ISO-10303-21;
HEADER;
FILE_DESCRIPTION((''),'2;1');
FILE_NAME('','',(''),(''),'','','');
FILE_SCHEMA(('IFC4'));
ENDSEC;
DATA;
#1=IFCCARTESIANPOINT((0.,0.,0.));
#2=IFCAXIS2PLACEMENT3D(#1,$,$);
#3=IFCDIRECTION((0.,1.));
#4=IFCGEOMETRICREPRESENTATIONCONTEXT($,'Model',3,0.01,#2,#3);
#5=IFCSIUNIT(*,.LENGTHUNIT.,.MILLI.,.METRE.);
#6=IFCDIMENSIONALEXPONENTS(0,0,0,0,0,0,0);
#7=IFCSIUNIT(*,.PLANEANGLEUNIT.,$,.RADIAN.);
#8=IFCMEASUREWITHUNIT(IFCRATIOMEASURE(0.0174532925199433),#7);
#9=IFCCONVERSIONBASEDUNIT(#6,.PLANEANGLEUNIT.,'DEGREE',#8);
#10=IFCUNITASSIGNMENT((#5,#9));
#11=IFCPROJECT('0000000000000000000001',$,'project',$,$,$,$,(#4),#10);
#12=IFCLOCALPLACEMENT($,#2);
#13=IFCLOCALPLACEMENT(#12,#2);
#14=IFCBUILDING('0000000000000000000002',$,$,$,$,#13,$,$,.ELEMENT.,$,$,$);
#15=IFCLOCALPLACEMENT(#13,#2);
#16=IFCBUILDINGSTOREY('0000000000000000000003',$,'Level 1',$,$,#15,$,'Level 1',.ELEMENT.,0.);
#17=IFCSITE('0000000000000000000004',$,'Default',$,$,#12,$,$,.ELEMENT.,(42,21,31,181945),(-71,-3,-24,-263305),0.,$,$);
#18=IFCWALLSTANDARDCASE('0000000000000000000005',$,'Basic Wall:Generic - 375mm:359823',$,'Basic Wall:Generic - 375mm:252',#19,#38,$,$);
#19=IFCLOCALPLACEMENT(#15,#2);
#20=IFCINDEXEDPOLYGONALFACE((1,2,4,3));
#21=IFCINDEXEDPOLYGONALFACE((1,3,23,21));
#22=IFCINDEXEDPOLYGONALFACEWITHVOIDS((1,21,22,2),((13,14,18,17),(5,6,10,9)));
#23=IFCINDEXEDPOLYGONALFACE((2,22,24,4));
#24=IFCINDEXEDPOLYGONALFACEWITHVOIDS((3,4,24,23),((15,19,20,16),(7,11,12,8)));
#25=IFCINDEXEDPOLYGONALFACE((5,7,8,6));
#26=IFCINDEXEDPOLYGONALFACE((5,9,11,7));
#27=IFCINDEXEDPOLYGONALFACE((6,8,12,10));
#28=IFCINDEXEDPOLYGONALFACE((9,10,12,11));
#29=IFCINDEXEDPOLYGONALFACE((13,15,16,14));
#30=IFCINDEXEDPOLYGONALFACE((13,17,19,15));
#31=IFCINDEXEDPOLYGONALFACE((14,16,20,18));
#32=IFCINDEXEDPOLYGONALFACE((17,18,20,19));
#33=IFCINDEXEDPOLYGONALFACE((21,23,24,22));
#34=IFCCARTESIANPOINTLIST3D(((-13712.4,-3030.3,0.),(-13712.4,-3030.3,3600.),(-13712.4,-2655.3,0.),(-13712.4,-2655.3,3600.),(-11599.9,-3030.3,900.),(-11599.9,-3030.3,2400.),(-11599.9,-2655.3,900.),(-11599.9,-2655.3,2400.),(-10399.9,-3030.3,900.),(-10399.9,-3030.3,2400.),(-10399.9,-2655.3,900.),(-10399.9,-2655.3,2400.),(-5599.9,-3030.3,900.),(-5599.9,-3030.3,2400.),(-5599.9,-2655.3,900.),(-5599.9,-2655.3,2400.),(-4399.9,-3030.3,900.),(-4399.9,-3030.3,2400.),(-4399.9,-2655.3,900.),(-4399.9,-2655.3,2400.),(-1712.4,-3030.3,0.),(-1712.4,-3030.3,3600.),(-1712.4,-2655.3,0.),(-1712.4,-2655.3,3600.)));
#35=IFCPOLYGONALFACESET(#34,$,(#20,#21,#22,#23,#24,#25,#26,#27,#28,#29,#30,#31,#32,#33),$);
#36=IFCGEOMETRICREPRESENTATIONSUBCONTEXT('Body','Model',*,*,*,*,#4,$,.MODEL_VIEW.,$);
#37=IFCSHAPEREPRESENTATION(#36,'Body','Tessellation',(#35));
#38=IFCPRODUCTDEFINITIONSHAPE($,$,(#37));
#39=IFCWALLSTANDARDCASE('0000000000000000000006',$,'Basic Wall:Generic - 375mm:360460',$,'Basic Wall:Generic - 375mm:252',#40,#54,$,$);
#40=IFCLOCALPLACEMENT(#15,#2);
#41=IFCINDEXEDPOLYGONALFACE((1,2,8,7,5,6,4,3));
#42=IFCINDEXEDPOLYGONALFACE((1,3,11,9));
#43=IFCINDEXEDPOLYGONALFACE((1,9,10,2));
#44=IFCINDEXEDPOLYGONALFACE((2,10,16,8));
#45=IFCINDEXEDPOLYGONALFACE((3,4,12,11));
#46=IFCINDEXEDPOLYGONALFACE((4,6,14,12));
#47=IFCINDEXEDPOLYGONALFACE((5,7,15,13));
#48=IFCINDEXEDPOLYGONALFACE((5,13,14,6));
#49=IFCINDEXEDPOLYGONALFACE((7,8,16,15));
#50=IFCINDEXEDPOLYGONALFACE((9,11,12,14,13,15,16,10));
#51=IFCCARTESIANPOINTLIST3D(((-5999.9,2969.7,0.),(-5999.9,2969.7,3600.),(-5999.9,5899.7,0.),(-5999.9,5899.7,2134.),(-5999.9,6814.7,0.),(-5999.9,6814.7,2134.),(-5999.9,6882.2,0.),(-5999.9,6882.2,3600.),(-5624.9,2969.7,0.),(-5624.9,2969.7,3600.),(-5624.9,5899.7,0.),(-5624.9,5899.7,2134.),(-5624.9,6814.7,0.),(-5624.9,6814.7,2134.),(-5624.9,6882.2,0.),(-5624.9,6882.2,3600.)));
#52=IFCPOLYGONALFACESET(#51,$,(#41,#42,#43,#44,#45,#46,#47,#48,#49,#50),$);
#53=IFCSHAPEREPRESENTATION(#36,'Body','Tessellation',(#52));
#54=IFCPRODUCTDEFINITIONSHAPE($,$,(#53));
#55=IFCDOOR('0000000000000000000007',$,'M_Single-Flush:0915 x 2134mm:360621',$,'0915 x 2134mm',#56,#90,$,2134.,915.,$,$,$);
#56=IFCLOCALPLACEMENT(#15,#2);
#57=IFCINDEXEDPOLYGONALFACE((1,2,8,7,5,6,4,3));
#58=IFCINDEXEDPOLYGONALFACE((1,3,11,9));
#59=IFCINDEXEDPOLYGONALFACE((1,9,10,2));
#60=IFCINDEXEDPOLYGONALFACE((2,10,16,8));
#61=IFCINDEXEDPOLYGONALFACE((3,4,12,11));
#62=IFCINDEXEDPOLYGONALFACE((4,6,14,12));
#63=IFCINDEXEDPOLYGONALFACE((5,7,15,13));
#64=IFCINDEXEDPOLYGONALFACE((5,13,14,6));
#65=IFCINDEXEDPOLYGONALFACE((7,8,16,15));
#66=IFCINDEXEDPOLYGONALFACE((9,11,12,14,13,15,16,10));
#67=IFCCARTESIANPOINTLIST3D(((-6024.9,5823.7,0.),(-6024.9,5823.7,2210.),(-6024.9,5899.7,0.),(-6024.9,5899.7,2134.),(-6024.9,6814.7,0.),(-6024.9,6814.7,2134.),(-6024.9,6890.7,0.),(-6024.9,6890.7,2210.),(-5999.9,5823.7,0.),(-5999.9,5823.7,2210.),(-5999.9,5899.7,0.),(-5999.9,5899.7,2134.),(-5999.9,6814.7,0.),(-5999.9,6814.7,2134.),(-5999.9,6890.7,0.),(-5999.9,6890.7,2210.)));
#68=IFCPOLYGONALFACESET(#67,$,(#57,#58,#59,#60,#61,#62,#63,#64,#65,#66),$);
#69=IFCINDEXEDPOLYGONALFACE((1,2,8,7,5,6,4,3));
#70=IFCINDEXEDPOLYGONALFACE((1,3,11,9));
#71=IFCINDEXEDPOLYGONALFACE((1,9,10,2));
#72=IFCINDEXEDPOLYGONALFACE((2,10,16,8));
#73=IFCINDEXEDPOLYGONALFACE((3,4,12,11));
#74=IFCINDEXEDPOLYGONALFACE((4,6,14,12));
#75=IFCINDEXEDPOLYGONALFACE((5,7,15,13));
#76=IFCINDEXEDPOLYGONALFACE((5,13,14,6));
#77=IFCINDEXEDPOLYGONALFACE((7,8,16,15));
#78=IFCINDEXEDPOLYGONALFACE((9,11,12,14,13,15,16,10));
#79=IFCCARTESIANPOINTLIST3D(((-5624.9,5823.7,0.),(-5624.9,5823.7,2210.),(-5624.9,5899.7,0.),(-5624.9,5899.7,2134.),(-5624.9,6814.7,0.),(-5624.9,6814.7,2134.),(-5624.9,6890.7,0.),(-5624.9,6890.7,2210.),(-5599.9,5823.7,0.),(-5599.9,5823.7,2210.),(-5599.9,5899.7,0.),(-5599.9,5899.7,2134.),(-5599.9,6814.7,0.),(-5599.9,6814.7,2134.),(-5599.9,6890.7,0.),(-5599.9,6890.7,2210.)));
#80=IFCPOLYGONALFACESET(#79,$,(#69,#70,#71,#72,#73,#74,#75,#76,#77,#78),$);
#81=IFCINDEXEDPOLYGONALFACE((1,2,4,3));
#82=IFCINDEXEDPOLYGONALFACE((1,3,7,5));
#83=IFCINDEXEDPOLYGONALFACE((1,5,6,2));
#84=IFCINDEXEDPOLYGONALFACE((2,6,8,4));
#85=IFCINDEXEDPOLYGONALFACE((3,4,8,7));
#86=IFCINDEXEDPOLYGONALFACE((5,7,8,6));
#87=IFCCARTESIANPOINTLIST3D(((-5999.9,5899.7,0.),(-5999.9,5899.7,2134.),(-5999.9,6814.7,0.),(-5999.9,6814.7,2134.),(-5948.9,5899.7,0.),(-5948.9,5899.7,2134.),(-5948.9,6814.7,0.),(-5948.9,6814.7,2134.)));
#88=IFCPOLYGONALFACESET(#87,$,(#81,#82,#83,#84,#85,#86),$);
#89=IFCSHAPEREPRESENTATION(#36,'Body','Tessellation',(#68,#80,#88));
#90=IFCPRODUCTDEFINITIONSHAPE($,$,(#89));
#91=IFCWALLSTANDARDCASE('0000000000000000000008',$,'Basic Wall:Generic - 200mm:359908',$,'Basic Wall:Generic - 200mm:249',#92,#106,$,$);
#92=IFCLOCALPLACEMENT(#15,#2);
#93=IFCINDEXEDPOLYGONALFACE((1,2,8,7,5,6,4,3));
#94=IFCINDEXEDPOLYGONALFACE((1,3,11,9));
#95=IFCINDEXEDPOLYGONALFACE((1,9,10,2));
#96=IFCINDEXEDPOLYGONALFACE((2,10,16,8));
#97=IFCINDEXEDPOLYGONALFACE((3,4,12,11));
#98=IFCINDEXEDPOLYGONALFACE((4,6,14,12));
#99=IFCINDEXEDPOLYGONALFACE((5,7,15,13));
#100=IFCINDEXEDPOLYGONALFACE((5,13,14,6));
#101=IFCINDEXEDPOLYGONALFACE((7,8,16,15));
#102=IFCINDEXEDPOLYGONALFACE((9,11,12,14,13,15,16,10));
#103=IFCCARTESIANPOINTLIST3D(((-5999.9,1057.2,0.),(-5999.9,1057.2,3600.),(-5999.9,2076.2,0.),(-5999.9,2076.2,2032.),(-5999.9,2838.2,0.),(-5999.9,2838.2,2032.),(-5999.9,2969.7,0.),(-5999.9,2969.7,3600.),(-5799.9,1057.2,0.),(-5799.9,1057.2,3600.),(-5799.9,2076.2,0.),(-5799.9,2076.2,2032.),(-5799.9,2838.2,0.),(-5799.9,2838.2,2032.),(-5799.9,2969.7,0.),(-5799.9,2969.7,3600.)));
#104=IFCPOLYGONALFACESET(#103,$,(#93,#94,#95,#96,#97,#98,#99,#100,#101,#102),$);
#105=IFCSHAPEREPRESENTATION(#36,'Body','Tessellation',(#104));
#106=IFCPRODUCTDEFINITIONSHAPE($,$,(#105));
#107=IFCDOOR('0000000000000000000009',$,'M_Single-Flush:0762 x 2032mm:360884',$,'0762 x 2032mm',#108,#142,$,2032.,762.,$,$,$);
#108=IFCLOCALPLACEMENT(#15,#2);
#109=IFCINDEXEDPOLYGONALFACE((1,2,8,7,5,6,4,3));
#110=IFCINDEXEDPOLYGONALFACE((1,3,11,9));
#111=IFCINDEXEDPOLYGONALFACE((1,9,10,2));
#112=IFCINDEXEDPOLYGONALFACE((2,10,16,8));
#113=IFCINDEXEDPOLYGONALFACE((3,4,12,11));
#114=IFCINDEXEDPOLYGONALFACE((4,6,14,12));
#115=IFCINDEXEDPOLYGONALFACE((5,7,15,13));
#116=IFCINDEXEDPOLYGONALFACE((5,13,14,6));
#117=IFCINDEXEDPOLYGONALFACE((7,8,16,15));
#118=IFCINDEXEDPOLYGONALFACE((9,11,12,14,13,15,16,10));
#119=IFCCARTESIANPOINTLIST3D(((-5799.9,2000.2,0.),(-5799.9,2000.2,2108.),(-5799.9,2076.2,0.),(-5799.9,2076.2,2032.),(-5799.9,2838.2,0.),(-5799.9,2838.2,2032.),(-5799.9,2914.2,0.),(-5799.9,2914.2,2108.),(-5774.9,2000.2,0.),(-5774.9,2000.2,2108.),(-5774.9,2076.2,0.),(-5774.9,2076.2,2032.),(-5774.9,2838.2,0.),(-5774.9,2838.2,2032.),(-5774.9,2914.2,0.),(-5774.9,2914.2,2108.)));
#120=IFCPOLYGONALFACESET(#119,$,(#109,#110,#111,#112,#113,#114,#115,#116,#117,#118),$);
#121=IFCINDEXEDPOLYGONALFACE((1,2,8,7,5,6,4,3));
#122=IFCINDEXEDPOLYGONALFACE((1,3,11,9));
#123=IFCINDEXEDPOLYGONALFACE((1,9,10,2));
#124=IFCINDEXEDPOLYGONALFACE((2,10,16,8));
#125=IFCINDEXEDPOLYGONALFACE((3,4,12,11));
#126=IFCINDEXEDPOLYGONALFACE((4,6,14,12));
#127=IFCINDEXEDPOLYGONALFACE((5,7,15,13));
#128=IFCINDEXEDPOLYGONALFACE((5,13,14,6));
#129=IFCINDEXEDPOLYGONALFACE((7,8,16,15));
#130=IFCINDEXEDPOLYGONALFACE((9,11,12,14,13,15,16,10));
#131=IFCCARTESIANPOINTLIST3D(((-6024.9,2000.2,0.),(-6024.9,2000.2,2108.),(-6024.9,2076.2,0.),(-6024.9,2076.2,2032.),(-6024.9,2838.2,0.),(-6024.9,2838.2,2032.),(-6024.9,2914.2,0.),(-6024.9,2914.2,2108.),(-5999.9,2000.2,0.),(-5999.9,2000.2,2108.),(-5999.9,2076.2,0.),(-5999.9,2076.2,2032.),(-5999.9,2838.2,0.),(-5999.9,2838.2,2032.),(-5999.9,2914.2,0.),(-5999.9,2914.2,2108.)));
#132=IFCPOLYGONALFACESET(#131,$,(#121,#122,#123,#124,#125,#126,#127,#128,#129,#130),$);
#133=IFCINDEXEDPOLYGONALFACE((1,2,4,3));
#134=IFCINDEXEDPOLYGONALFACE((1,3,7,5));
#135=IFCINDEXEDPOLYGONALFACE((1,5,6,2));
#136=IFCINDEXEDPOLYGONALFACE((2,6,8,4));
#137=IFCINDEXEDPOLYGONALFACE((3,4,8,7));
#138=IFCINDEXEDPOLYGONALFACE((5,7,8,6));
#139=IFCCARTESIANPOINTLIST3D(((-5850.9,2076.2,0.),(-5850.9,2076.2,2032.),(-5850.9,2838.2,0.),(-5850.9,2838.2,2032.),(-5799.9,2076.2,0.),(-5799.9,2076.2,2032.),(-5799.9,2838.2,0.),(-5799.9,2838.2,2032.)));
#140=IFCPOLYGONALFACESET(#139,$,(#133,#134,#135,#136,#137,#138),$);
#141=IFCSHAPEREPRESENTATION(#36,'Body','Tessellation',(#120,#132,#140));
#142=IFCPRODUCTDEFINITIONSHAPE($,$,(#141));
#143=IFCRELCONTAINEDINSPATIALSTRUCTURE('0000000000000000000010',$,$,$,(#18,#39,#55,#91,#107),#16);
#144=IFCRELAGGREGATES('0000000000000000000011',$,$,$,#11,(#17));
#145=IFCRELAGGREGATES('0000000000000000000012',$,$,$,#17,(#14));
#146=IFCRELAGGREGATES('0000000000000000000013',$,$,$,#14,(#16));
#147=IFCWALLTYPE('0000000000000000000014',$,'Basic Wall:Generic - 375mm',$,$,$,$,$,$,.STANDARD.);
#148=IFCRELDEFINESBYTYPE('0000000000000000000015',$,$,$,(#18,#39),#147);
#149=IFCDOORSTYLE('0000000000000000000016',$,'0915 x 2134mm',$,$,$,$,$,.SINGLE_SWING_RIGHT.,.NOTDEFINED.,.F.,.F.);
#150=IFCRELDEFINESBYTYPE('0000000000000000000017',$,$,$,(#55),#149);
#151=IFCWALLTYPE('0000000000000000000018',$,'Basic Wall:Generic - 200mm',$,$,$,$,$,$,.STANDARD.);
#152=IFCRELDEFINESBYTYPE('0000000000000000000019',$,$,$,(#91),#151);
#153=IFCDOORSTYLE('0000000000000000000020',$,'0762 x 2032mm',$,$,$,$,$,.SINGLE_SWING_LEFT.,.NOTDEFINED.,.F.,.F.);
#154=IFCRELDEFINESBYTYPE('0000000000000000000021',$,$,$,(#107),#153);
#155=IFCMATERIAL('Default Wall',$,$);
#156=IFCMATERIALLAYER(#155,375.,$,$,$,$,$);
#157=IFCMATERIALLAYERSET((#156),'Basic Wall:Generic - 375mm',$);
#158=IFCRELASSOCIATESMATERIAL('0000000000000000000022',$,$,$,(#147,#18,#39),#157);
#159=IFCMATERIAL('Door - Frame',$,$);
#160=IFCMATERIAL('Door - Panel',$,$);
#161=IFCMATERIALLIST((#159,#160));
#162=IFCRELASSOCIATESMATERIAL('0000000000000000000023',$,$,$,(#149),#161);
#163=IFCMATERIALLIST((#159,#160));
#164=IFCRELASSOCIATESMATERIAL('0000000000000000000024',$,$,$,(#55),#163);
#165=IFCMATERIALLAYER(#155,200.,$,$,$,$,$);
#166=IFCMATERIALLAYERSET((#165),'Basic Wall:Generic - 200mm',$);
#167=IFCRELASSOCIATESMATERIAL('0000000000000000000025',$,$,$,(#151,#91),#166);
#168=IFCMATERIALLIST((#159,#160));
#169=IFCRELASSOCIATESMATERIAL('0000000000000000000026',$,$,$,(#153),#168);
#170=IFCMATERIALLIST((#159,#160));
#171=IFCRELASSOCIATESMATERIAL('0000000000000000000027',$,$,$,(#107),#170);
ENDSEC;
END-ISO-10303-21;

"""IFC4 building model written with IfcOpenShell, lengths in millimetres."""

from ifc_helpers import new_model, entity, si_unit, converted_unit, direction, frame, frame_2d, origin, place, context, subcontext, project, spatial, polyline, rectangle, outline, extrude, clip, bounded_halfspace, source, transform, mapped, material, material_list, layer, layer_set, layer_usage, type_object, type_shapes, element, fill, save


model = new_model("IFC4")

# Units and contexts
model_context = context("Model", 3, precision=0.01, world=origin(), true_north=direction((0.0, 1.0)))
body_context = subcontext(model_context, "Body", "Model", "MODEL_VIEW")
ifc_project = project(units=[si_unit("LENGTHUNIT", "METRE", prefix="MILLI"), converted_unit("PLANEANGLEUNIT", "DEGREE", entity("IfcRatioMeasure", 0.0174532925199433), si_unit("PLANEANGLEUNIT", "RADIAN"), dimensions=[0, 0, 0, 0, 0, 0, 0])], contexts=[model_context])

# Site, building, storey
site_placement = place(None, origin())
site = spatial("IfcSite", under=ifc_project, at=site_placement, Name="Default", CompositionType="ELEMENT", RefLatitude=(42, 21, 31, 181945), RefLongitude=(-71, -3, -24, -263305), RefElevation=0.0)
building_placement = place(site_placement, origin())
building = spatial("IfcBuilding", under=site, at=building_placement, CompositionType="ELEMENT")
storey_placement = place(building_placement, origin())
storey = spatial("IfcBuildingStorey", under=building, at=storey_placement, Name="Level 1", LongName="Level 1", CompositionType="ELEMENT", Elevation=0.0)

# Wall, openings
ifc_material_1 = material(Name="Default Wall")
ifc_layer_1 = layer(ifc_material_1, 375.0)
ifc_layer_set_1 = layer_set([ifc_layer_1], Name="Basic Wall:Generic - 375mm")
ifc_layer_usage_1 = layer_usage(ifc_layer_set_1, "AXIS2", "NEGATIVE", 187.5)
wall_type_1 = type_object("IfcWallType", Name="Basic Wall:Generic - 375mm", PredefinedType="STANDARD", material=ifc_layer_set_1)
wall_1_placement = place(storey_placement, frame((-13712.4, -2842.8, 0.0)))
wall_1 = element("IfcWallStandardCase", 1, at=wall_1_placement, inside=storey, type_object=wall_type_1, material=ifc_layer_usage_1, Name="Basic Wall:Generic - 375mm:359823", ObjectType="Basic Wall:Generic - 375mm:252", context=body_context, shape_type="Clipping", body=[
    clip(extrude(rectangle(XDim=12000.0, YDim=375.0, at=frame_2d((6000.0, 0.0), x_axis=(-1.0, 0.0))), origin(), (0.0, 0.0, 1.0), 3600.0), bounded_halfspace(frame((0.0, -187.5, 3600.0), z_axis=(0.0, 0.0, -1.0), x_axis=(1.0, 0.0, 0.0)), True, frame((0.0, -187.5, 3600.0)), polyline([(0.0, 0.0), (12000.0, 0.0), (12000.0, 375.0), (11625.0, 375.0), (5712.5, 375.0), (5512.5, 375.0), (0.0, 375.0), (0.0, 0.0)]))),
])
opening_1_placement = place(wall_1_placement, frame((2112.5, -187.5, 900.0)))
element("IfcOpeningElement", 2, at=opening_1_placement, cuts=wall_1, ObjectType="Opening", context=body_context, shape_type="SweptSolid", body=[
    extrude(rectangle(XDim=1500.0, YDim=1200.0, at=frame_2d((750.0, 600.0), x_axis=(-1.0, 0.0))), frame((0.0, 0.0, 0.0), z_axis=(0.0, 1.0, 0.0), x_axis=(0.0, 0.0, 1.0)), (0.0, 0.0, 1.0), 375.0),
])
opening_2_placement = place(wall_1_placement, frame((8112.5, -187.5, 900.0)))
element("IfcOpeningElement", 3, at=opening_2_placement, cuts=wall_1, ObjectType="Opening", context=body_context, shape_type="SweptSolid", body=[
    extrude(rectangle(XDim=1500.0, YDim=1200.0, at=frame_2d((750.0, 600.0), x_axis=(-1.0, 0.0))), frame((0.0, 0.0, 0.0), z_axis=(0.0, 1.0, 0.0), x_axis=(0.0, 0.0, 1.0)), (0.0, 0.0, 1.0), 375.0),
])

# Walls, openings, doors
ifc_layer_usage_2 = layer_usage(ifc_layer_set_1, "AXIS2", "NEGATIVE", 187.5)
wall_2_placement = place(storey_placement, frame((-5812.4, 2969.7, 0.0), z_axis=(0.0, 0.0, 1.0), x_axis=(0.0, 1.0, 0.0)))
wall_2 = element("IfcWallStandardCase", 4, at=wall_2_placement, inside=storey, type_object=wall_type_1, material=ifc_layer_usage_2, Name="Basic Wall:Generic - 375mm:360460", ObjectType="Basic Wall:Generic - 375mm:252", context=body_context, shape_type="Clipping", body=[
    clip(extrude(rectangle(XDim=3912.5, YDim=375.0, at=frame_2d((1956.3, 0.0), x_axis=(-1.0, 0.0))), origin(), (0.0, 0.0, 1.0), 3600.0), bounded_halfspace(frame((0.0, -187.5, 3600.0), z_axis=(0.0, 0.0, -1.0), x_axis=(0.0, -1.0, 0.0)), True, frame((0.0, -187.5, 3600.0)), polyline([(0.0, 0.0), (375.0, 0.0), (3912.5, 0.0), (3912.5, 375.0), (0.0, 375.0), (0.0, 175.0), (0.0, 0.0)]))),
])
opening_3_placement = place(wall_2_placement, frame((2930.0, -187.5, 0.0)))
opening_3 = element("IfcOpeningElement", 5, at=opening_3_placement, cuts=wall_2, ObjectType="Opening", context=body_context, shape_type="SweptSolid", body=[
    extrude(rectangle(XDim=915.0, YDim=2134.0, at=frame_2d((1067.0, 457.5), x_axis=(0.0, 1.0))), frame((0.0, 0.0, 0.0), z_axis=(0.0, 1.0, 0.0), x_axis=(0.0, 0.0, 1.0)), (0.0, 0.0, 1.0), 375.0),
])
ifc_material_2 = material(Name="Door - Frame")
ifc_material_3 = material(Name="Door - Panel")
ifc_material_list_1 = material_list([ifc_material_2, ifc_material_3])
ifc_material_list_2 = material_list([ifc_material_2, ifc_material_3])
door_style_1 = type_object("IfcDoorStyle", Name="0915 x 2134mm", ConstructionType="NOTDEFINED", OperationType="SINGLE_SWING_RIGHT", ParameterTakesPrecedence=False, Sizeable=False, material=ifc_material_list_2)
shared_shape_1 = source(origin(), body_context, "Body", "SweptSolid", [
    extrude(outline(polyline([(-533.5, -1124.0), (533.5, -1124.0), (533.5, 1086.0), (457.5, 1086.0), (457.5, -1048.0), (-457.5, -1048.0), (-457.5, 1086.0), (-533.5, 1086.0), (-533.5, -1124.0)])), frame((457.5, 375.0, 1086.0), z_axis=(0.0, 1.0, 0.0), x_axis=(1.0, 0.0, 0.0)), (0.0, 0.0, 1.0), 25.0),
    extrude(outline(polyline([(-1124.0, -533.5), (1086.0, -533.5), (1086.0, -457.5), (-1048.0, -457.5), (-1048.0, 457.5), (1086.0, 457.5), (1086.0, 533.5), (-1124.0, 533.5), (-1124.0, -533.5)])), frame((457.5, -25.0, 1086.0), z_axis=(0.0, 1.0, 0.0), x_axis=(0.0, 0.0, -1.0)), (0.0, 0.0, 1.0), 25.0),
    extrude(rectangle(XDim=51.0, YDim=915.0, at=frame_2d((0.0, 0.0), x_axis=(1.0, 0.0))), frame((457.5, 349.5, 0.0), z_axis=(0.0, 0.0, 1.0), x_axis=(0.0, 1.0, 0.0)), (0.0, 0.0, 1.0), 2134.0),
])
type_shapes(door_style_1, [shared_shape_1])
door_1_placement = place(opening_3_placement, origin())
door_1 = element("IfcDoor", 6, at=door_1_placement, inside=storey, type_object=door_style_1, material=ifc_material_list_1, Name="M_Single-Flush:0915 x 2134mm:360621", ObjectType="0915 x 2134mm", OverallHeight=2134.0, OverallWidth=915.0, context=body_context, shape_type="MappedRepresentation", body=[
    mapped(shared_shape_1, transform((0.0, 0.0, 0.0), scale=1.0)),
])
fill(opening_3, door_1)
ifc_layer_2 = layer(ifc_material_1, 200.0)
ifc_layer_set_2 = layer_set([ifc_layer_2], Name="Basic Wall:Generic - 200mm")
ifc_layer_usage_3 = layer_usage(ifc_layer_set_2, "AXIS2", "NEGATIVE", 100.0)
wall_type_2 = type_object("IfcWallType", Name="Basic Wall:Generic - 200mm", PredefinedType="STANDARD", material=ifc_layer_set_2)
wall_3_placement = place(storey_placement, frame((-5899.9, 1057.2, 0.0), z_axis=(0.0, 0.0, 1.0), x_axis=(0.0, 1.0, 0.0)))
wall_3 = element("IfcWallStandardCase", 7, at=wall_3_placement, inside=storey, type_object=wall_type_2, material=ifc_layer_usage_3, Name="Basic Wall:Generic - 200mm:359908", ObjectType="Basic Wall:Generic - 200mm:249", context=body_context, shape_type="Clipping", body=[
    clip(extrude(rectangle(XDim=1912.5, YDim=200.0, at=frame_2d((956.3, 0.0), x_axis=(-1.0, 0.0))), origin(), (0.0, 0.0, 1.0), 3600.0), bounded_halfspace(frame((0.0, -100.0, 3600.0), z_axis=(0.0, 0.0, -1.0), x_axis=(0.0, -1.0, 0.0)), True, frame((0.0, -100.0, 3600.0)), polyline([(0.0, 0.0), (1912.5, 0.0), (1912.5, 200.0), (0.0, 200.0), (0.0, 0.0)]))),
])
opening_4_placement = place(wall_3_placement, frame((1781.0, 100.0, 0.0)))
opening_4 = element("IfcOpeningElement", 8, at=opening_4_placement, cuts=wall_3, ObjectType="Opening", context=body_context, shape_type="SweptSolid", body=[
    extrude(rectangle(XDim=762.0, YDim=2032.0, at=frame_2d((1016.0, 381.0), x_axis=(0.0, -1.0))), frame((0.0, 0.0, 0.0), z_axis=(0.0, -1.0, 0.0), x_axis=(0.0, 0.0, 1.0)), (0.0, 0.0, 1.0), 200.0),
])
ifc_material_list_3 = material_list([ifc_material_2, ifc_material_3])
ifc_material_list_4 = material_list([ifc_material_2, ifc_material_3])
door_style_2 = type_object("IfcDoorStyle", Name="0762 x 2032mm", ConstructionType="NOTDEFINED", OperationType="SINGLE_SWING_LEFT", ParameterTakesPrecedence=False, Sizeable=False, material=ifc_material_list_4)
shared_shape_2 = source(origin(), body_context, "Body", "SweptSolid", [
    extrude(outline(polyline([(-457.0, -1073.0), (457.0, -1073.0), (457.0, 1035.0), (381.0, 1035.0), (381.0, -997.0), (-381.0, -997.0), (-381.0, 1035.0), (-457.0, 1035.0), (-457.0, -1073.0)])), frame((381.0, 225.0, 1035.0), z_axis=(0.0, -1.0, 0.0), x_axis=(-1.0, 0.0, 0.0)), (0.0, 0.0, 1.0), 25.0),
    extrude(outline(polyline([(-1073.0, -457.0), (1035.0, -457.0), (1035.0, -381.0), (-997.0, -381.0), (-997.0, 381.0), (1035.0, 381.0), (1035.0, 457.0), (-1073.0, 457.0), (-1073.0, -457.0)])), frame((381.0, 0.0, 1035.0), z_axis=(0.0, -1.0, 0.0), x_axis=(0.0, 0.0, -1.0)), (0.0, 0.0, 1.0), 25.0),
    extrude(rectangle(XDim=762.0, YDim=51.0, at=frame_2d((0.0, 0.0), x_axis=(1.0, 0.0))), frame((381.0, 174.5, 0.0)), (0.0, 0.0, 1.0), 2032.0),
])
type_shapes(door_style_2, [shared_shape_2])
door_2_placement = place(opening_4_placement, frame((0.0, 0.0, 0.0), z_axis=(0.0, 0.0, 1.0), x_axis=(-1.0, 0.0, 0.0)))
door_2 = element("IfcDoor", 9, at=door_2_placement, inside=storey, type_object=door_style_2, material=ifc_material_list_3, Name="M_Single-Flush:0762 x 2032mm:360884", ObjectType="0762 x 2032mm", OverallHeight=2032.0, OverallWidth=762.0, context=body_context, shape_type="MappedRepresentation", body=[
    mapped(shared_shape_2, transform((0.0, 0.0, 0.0), scale=1.0)),
])
fill(opening_4, door_2)

save(model, "model.ifc")
